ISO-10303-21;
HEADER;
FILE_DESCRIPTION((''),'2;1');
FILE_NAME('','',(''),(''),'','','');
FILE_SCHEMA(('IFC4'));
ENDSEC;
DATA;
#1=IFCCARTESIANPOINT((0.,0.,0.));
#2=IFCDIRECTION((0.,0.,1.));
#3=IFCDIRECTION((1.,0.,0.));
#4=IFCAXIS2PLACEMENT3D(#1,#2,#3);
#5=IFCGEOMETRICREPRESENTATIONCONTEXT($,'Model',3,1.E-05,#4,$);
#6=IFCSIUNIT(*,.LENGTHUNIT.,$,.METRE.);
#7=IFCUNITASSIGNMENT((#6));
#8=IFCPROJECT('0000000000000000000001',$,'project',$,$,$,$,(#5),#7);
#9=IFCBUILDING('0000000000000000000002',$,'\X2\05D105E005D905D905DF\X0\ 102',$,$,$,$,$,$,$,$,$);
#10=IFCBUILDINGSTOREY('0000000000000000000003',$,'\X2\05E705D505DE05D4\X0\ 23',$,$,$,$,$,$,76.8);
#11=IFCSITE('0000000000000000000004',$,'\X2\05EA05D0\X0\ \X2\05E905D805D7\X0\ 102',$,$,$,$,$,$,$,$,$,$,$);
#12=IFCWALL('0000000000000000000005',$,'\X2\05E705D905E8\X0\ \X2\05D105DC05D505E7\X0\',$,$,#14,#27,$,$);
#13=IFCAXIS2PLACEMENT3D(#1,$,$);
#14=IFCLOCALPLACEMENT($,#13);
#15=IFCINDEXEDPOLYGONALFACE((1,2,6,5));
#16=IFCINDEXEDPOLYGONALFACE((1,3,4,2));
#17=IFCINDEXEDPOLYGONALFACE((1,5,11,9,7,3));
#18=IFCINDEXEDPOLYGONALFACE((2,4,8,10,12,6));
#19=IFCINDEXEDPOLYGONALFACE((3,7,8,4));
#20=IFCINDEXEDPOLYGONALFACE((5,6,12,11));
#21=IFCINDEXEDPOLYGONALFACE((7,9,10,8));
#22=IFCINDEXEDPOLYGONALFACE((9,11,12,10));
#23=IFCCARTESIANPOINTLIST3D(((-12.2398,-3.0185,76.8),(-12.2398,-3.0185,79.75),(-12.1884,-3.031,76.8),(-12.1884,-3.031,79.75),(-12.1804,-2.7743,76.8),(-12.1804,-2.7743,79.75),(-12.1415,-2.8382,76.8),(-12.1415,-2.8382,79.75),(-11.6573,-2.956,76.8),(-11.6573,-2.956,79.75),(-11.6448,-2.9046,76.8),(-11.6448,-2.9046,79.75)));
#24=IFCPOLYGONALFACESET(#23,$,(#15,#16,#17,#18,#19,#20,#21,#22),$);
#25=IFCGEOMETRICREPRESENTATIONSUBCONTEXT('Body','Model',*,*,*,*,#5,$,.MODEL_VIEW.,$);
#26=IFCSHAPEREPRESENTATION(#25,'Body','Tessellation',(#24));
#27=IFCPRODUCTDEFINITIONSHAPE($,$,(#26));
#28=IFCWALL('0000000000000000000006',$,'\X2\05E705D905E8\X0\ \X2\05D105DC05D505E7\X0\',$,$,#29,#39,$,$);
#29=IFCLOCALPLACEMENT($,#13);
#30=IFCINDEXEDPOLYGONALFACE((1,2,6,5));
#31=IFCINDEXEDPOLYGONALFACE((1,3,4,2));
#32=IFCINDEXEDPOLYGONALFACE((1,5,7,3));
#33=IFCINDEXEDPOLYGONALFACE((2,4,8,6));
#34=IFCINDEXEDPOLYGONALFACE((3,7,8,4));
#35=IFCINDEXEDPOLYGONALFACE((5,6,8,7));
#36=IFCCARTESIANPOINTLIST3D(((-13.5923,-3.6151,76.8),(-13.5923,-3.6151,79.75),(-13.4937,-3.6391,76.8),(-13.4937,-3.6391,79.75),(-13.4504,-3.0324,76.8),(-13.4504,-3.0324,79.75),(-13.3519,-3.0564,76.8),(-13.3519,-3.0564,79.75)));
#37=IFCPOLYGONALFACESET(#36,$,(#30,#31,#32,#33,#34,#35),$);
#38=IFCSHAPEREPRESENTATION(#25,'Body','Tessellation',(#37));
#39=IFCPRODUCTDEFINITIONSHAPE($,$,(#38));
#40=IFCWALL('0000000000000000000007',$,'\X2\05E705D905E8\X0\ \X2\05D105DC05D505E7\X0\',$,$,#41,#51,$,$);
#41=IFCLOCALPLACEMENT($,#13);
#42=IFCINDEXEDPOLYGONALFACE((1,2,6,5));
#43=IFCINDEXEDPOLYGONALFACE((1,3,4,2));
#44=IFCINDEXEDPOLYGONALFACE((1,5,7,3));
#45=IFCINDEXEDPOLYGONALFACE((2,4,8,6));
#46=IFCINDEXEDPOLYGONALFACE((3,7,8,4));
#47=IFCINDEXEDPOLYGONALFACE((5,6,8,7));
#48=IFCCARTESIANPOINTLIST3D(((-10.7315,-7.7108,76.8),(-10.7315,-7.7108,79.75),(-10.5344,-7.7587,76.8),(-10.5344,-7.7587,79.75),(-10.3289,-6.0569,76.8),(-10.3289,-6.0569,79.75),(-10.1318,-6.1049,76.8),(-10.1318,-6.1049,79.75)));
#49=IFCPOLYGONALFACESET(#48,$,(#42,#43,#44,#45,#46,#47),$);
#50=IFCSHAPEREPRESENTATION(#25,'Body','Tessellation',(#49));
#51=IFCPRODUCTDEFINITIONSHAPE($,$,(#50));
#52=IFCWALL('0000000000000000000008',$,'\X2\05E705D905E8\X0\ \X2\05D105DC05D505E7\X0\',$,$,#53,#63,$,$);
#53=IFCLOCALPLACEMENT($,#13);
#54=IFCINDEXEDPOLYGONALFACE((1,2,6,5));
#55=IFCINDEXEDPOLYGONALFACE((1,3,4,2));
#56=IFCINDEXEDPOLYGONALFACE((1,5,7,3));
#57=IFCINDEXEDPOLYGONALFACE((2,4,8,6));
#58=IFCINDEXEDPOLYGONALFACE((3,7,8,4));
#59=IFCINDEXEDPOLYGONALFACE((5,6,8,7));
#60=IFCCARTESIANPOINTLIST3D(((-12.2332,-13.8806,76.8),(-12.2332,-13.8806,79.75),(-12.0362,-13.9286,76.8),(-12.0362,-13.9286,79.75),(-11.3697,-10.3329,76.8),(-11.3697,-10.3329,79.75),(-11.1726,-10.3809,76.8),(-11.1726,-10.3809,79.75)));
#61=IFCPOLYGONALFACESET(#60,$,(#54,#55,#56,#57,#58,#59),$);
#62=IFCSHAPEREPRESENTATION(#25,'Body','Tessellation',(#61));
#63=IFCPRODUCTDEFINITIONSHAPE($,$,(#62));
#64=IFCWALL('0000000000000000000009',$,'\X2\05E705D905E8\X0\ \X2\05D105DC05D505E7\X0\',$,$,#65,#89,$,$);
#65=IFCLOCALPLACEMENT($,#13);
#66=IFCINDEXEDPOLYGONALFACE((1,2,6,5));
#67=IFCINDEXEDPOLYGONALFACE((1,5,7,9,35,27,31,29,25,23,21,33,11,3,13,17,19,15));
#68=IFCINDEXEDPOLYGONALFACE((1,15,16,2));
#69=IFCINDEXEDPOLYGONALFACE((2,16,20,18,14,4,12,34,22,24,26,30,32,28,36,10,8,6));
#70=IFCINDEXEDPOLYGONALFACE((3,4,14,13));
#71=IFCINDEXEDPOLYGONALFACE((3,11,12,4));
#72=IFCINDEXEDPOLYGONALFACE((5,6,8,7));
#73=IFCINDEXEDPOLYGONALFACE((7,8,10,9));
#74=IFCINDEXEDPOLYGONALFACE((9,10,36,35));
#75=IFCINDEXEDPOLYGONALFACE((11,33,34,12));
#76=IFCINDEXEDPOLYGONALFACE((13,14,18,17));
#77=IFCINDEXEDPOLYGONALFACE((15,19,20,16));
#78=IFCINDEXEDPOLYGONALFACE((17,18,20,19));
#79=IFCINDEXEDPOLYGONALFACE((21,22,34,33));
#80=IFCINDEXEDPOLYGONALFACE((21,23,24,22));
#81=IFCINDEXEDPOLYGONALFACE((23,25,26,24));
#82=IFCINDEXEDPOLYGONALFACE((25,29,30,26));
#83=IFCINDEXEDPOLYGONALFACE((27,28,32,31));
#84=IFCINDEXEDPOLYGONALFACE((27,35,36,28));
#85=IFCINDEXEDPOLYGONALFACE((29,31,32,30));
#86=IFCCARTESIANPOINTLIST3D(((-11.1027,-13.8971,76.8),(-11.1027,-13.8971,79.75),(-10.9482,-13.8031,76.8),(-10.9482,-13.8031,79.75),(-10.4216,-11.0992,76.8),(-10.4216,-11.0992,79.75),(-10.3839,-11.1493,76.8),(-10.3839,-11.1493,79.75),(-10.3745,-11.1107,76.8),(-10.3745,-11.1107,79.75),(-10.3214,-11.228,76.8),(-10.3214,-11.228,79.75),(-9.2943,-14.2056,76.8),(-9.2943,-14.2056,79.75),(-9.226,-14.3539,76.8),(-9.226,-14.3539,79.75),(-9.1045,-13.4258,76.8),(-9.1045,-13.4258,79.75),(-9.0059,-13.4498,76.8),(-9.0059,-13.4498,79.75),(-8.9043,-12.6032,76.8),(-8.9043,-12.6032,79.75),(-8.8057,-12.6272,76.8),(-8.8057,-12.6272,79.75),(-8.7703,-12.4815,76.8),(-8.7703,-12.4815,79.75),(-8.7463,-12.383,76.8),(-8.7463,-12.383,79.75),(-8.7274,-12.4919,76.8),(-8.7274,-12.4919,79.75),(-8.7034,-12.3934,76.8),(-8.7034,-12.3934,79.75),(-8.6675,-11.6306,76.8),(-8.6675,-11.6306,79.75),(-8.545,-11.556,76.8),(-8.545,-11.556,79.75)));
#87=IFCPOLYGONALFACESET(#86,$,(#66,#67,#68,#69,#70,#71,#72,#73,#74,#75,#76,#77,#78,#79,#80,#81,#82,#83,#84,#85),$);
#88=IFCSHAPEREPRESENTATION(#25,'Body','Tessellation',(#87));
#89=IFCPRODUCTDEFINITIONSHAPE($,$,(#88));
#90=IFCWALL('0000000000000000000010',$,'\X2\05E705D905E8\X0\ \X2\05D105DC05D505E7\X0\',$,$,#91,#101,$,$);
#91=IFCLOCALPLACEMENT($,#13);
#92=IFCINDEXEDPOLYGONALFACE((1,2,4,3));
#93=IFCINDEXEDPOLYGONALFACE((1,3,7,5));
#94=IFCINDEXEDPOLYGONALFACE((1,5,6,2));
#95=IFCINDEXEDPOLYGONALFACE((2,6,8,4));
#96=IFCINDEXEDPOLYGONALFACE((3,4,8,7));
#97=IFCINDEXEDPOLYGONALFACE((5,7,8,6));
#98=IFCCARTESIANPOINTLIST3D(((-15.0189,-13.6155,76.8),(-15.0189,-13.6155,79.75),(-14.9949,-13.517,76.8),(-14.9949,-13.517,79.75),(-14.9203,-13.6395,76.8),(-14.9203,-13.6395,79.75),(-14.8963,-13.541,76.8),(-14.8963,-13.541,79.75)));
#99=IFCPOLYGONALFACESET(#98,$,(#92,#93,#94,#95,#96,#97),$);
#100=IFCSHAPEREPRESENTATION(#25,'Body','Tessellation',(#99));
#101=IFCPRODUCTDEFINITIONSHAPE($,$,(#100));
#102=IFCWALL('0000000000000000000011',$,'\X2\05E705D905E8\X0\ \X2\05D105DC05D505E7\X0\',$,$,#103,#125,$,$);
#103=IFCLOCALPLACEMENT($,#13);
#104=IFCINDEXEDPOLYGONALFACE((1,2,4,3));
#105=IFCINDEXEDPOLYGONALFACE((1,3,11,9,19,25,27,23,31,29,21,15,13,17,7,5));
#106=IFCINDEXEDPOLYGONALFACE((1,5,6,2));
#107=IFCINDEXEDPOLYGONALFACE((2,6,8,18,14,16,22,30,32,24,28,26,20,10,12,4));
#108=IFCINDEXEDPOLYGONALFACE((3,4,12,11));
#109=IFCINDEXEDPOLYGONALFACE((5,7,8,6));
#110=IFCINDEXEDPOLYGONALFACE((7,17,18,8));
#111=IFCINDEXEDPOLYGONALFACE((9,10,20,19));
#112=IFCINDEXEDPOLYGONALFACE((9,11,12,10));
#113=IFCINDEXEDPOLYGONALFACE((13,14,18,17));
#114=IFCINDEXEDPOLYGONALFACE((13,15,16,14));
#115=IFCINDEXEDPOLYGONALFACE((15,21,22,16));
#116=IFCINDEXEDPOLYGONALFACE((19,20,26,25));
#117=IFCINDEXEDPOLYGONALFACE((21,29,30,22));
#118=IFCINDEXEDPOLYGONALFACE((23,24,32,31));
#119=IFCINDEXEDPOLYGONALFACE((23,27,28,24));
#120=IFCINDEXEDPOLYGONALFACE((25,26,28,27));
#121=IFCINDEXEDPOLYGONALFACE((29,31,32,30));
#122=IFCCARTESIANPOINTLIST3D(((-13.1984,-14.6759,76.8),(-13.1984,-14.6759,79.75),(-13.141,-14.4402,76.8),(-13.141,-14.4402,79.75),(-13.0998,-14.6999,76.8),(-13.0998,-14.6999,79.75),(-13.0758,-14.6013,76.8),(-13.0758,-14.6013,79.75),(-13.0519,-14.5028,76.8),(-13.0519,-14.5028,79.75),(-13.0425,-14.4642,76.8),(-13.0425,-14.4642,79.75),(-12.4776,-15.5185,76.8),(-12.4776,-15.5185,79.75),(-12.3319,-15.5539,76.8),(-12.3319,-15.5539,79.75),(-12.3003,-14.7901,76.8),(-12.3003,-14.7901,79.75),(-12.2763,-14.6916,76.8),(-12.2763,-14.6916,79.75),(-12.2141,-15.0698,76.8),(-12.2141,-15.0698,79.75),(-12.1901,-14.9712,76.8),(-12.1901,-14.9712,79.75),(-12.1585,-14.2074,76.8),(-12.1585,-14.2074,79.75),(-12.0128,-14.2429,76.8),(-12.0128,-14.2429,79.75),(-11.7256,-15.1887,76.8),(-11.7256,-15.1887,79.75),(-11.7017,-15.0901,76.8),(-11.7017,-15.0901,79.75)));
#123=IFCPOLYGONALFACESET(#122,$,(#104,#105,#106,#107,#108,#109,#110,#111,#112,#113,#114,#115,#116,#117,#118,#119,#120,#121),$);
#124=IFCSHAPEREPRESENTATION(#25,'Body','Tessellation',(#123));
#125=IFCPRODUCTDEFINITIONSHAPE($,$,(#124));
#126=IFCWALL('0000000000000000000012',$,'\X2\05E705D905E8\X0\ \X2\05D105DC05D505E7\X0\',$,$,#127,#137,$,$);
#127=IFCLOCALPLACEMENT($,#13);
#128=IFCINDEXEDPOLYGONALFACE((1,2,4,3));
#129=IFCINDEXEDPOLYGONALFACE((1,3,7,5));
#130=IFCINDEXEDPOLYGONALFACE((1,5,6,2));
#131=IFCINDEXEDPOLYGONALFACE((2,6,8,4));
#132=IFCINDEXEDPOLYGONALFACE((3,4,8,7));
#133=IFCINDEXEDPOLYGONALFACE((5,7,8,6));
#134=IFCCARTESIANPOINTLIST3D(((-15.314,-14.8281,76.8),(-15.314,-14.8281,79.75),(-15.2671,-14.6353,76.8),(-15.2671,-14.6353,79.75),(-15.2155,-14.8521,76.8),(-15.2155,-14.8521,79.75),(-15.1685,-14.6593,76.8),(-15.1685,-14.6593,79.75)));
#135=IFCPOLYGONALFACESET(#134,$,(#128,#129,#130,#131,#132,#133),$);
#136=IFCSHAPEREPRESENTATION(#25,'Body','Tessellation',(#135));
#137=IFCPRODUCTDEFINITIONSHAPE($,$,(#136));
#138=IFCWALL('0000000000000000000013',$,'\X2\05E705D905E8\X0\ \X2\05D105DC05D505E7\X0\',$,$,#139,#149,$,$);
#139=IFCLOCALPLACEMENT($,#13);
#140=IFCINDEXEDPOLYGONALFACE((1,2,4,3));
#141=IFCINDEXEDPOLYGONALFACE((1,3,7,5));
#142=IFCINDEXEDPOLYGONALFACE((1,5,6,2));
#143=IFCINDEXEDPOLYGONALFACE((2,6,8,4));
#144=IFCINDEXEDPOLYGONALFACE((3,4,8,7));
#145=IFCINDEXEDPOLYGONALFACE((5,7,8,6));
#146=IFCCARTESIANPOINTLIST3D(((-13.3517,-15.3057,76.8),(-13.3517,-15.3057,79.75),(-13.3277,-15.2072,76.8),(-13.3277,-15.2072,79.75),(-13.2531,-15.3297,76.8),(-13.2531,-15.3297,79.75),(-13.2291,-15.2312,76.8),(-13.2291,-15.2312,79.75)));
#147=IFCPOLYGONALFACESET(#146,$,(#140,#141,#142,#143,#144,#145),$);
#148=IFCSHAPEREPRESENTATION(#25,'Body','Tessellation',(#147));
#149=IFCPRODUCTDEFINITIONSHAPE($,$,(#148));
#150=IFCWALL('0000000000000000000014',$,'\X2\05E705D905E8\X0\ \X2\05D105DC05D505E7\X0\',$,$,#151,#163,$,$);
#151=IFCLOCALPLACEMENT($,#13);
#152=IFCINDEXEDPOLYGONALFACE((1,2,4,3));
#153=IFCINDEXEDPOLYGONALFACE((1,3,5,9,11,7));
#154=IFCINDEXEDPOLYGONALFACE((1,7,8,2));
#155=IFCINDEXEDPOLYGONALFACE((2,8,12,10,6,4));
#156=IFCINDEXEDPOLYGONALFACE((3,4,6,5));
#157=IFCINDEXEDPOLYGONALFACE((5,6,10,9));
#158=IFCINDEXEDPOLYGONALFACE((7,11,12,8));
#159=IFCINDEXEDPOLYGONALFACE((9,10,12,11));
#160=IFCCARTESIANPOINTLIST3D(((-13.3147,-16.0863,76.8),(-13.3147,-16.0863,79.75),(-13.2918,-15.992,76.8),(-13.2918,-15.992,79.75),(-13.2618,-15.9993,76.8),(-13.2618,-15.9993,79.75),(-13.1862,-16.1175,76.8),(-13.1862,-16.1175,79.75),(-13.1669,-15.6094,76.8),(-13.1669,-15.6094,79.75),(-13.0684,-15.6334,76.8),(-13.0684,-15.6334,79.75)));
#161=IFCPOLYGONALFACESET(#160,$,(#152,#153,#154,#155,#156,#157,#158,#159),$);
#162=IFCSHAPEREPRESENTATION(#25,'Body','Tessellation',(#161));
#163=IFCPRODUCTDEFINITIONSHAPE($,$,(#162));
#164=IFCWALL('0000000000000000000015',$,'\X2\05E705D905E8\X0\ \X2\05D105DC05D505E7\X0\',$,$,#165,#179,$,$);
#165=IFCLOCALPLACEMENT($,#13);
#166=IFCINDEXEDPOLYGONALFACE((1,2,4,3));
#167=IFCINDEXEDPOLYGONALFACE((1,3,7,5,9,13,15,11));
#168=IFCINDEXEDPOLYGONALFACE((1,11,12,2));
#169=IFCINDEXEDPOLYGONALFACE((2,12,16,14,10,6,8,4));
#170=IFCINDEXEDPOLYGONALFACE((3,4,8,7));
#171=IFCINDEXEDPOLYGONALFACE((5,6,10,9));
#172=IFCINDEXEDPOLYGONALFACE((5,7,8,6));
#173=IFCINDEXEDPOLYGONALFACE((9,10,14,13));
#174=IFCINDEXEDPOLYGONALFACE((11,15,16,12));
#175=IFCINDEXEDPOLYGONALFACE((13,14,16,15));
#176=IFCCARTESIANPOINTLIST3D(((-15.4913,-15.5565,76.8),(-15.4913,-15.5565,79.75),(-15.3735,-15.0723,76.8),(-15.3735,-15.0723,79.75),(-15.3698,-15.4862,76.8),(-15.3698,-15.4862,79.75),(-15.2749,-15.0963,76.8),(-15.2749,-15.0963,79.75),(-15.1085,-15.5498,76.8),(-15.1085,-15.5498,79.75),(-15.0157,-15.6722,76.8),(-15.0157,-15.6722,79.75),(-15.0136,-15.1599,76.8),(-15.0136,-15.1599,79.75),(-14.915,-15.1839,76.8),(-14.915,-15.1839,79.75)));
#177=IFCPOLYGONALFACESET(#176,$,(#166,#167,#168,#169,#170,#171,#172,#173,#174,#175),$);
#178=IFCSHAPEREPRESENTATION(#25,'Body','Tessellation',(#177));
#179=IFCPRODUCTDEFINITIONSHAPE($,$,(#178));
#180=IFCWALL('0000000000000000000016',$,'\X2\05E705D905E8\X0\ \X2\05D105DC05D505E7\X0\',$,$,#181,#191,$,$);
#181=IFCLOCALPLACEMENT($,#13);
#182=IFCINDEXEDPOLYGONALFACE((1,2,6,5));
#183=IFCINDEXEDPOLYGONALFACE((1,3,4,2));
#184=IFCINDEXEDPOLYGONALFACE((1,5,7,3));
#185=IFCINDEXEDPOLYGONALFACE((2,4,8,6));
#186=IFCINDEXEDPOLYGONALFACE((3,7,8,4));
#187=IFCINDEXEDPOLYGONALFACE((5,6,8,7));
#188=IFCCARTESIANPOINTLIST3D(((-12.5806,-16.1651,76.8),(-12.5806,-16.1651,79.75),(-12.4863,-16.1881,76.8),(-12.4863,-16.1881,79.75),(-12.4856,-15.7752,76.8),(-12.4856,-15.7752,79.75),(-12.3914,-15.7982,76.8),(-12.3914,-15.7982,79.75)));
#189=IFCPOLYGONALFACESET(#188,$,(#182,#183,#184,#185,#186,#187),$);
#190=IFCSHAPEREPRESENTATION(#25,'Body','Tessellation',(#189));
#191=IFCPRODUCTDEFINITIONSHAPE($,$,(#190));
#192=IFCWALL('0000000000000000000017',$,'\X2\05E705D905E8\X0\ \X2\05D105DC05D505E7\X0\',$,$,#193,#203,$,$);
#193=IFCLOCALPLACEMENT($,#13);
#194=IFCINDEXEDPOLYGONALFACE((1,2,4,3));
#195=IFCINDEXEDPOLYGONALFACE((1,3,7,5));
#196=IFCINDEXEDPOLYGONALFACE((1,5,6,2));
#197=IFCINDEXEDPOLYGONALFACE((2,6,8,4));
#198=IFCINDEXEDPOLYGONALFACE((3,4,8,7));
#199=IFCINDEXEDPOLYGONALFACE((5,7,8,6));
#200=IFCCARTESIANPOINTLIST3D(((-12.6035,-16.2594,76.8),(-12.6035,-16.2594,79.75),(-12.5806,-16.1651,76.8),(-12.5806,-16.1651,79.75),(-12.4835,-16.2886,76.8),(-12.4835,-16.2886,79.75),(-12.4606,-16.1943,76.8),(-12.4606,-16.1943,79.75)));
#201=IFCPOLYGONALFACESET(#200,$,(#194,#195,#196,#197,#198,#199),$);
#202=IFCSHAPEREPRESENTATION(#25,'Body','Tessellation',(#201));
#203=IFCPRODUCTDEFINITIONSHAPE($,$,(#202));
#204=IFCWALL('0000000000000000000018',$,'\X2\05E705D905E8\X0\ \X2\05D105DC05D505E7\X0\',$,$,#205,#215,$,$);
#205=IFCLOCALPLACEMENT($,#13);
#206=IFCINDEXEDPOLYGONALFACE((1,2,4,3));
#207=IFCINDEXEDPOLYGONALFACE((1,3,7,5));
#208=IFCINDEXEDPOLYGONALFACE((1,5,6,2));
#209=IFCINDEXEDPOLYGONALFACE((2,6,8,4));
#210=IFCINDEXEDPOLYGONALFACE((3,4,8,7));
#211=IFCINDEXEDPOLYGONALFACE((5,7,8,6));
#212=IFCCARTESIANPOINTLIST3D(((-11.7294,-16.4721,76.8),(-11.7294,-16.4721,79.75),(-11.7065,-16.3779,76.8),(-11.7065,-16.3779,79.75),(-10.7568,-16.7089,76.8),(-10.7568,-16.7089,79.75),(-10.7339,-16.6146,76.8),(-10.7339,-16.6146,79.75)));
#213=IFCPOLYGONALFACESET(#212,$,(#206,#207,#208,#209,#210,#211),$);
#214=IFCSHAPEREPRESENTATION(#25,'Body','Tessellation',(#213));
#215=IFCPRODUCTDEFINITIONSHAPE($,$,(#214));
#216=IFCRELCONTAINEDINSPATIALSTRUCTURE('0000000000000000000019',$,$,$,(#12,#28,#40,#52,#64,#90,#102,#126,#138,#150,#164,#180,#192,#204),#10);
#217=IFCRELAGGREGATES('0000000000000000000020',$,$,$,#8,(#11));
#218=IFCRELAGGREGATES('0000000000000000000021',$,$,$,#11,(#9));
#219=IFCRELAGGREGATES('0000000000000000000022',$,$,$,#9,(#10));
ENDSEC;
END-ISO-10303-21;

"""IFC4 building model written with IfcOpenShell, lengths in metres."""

from ifc_helpers import new_model, si_unit, frame, origin_with_axes, context, subcontext, project, spatial, polyline, outline, extrude, element, save


model = new_model("IFC4")

# Units and contexts
model_context = context("Model", 3, precision=1e-05, world=origin_with_axes())
body_context = subcontext(model_context, "Body", "Model", "MODEL_VIEW")
ifc_project = project(units=[si_unit("LENGTHUNIT", "METRE")], contexts=[model_context])

# Site, building, storey
site = spatial("IfcSite", under=ifc_project, Name="תא שטח 102")
building = spatial("IfcBuilding", under=site, Name="בניין 102")
storey = spatial("IfcBuildingStorey", under=building, Name="קומה 23", Elevation=76.8)

# Walls
element("IfcWall", 1, inside=storey, Name="קיר בלוק", context=body_context, shape_type="SweptSolid", body=[
    extrude(outline(polyline([(-12.1415, -2.8382), (-11.6573, -2.956), (-11.6448, -2.9046), (-12.1804, -2.7743), (-12.2398, -3.0185), (-12.1884, -3.031), (-12.1415, -2.8382)])), frame((0.0, 0.0, 76.8)), (0.0, 0.0, 1.0), 2.95),
])
element("IfcWall", 2, inside=storey, Name="קיר בלוק", context=body_context, shape_type="SweptSolid", body=[
    extrude(outline(polyline([(-13.4504, -3.0324), (-13.5923, -3.6151), (-13.4937, -3.6391), (-13.3519, -3.0564), (-13.4504, -3.0324)])), frame((0.0, 0.0, 76.8)), (0.0, 0.0, 1.0), 2.95),
])
element("IfcWall", 3, inside=storey, Name="קיר בלוק", context=body_context, shape_type="SweptSolid", body=[
    extrude(outline(polyline([(-10.7315, -7.7108), (-10.5344, -7.7587), (-10.1318, -6.1049), (-10.3289, -6.0569), (-10.7315, -7.7108)])), frame((0.0, 0.0, 76.8)), (0.0, 0.0, 1.0), 2.95),
])
element("IfcWall", 4, inside=storey, Name="קיר בלוק", context=body_context, shape_type="SweptSolid", body=[
    extrude(outline(polyline([(-12.2332, -13.8806), (-12.0362, -13.9286), (-11.1726, -10.3809), (-11.3697, -10.3329), (-12.2332, -13.8806)])), frame((0.0, 0.0, 76.8)), (0.0, 0.0, 1.0), 2.95),
])
element("IfcWall", 5, inside=storey, Name="קיר בלוק", context=body_context, shape_type="SweptSolid", body=[
    extrude(outline(polyline([(-11.1027, -13.8971), (-9.226, -14.3539), (-9.0059, -13.4498), (-9.1045, -13.4258), (-9.2943, -14.2056), (-10.9482, -13.8031), (-10.3214, -11.228), (-8.6675, -11.6306), (-8.9043, -12.6032), (-8.8057, -12.6272), (-8.7703, -12.4815), (-8.7274, -12.4919), (-8.7034, -12.3934), (-8.7463, -12.383), (-8.545, -11.556), (-10.3745, -11.1107), (-10.3839, -11.1493), (-10.4216, -11.0992), (-11.1027, -13.8971)])), frame((0.0, 0.0, 76.8)), (0.0, 0.0, 1.0), 2.95),
])
element("IfcWall", 6, inside=storey, Name="קיר בלוק", context=body_context, shape_type="SweptSolid", body=[
    extrude(outline(polyline([(-14.9949, -13.517), (-15.0189, -13.6155), (-14.9203, -13.6395), (-14.8963, -13.541), (-14.9949, -13.517)])), frame((0.0, 0.0, 76.8)), (0.0, 0.0, 1.0), 2.95),
])
element("IfcWall", 7, inside=storey, Name="קיר בלוק", context=body_context, shape_type="SweptSolid", body=[
    extrude(outline(polyline([(-13.0998, -14.6999), (-13.0758, -14.6013), (-12.3003, -14.7901), (-12.4776, -15.5185), (-12.3319, -15.5539), (-12.2141, -15.0698), (-11.7256, -15.1887), (-11.7017, -15.0901), (-12.1901, -14.9712), (-12.0128, -14.2429), (-12.1585, -14.2074), (-12.2763, -14.6916), (-13.0519, -14.5028), (-13.0425, -14.4642), (-13.141, -14.4402), (-13.1984, -14.6759), (-13.0998, -14.6999)])), frame((0.0, 0.0, 76.8)), (0.0, 0.0, 1.0), 2.95),
])
element("IfcWall", 8, inside=storey, Name="קיר בלוק", context=body_context, shape_type="SweptSolid", body=[
    extrude(outline(polyline([(-15.1685, -14.6593), (-15.2671, -14.6353), (-15.314, -14.8281), (-15.2155, -14.8521), (-15.1685, -14.6593)])), frame((0.0, 0.0, 76.8)), (0.0, 0.0, 1.0), 2.95),
])
element("IfcWall", 9, inside=storey, Name="קיר בלוק", context=body_context, shape_type="SweptSolid", body=[
    extrude(outline(polyline([(-13.3277, -15.2072), (-13.3517, -15.3057), (-13.2531, -15.3297), (-13.2291, -15.2312), (-13.3277, -15.2072)])), frame((0.0, 0.0, 76.8)), (0.0, 0.0, 1.0), 2.95),
])
element("IfcWall", 10, inside=storey, Name="קיר בלוק", context=body_context, shape_type="SweptSolid", body=[
    extrude(outline(polyline([(-13.3147, -16.0863), (-13.1862, -16.1175), (-13.0684, -15.6334), (-13.1669, -15.6094), (-13.2618, -15.9993), (-13.2918, -15.992), (-13.3147, -16.0863)])), frame((0.0, 0.0, 76.8)), (0.0, 0.0, 1.0), 2.95),
])
element("IfcWall", 11, inside=storey, Name="קיר בלוק", context=body_context, shape_type="SweptSolid", body=[
    extrude(outline(polyline([(-15.3735, -15.0723), (-15.4913, -15.5565), (-15.0157, -15.6722), (-14.915, -15.1839), (-15.0136, -15.1599), (-15.1085, -15.5498), (-15.3698, -15.4862), (-15.2749, -15.0963), (-15.3735, -15.0723)])), frame((0.0, 0.0, 76.8)), (0.0, 0.0, 1.0), 2.95),
])
element("IfcWall", 12, inside=storey, Name="קיר בלוק", context=body_context, shape_type="SweptSolid", body=[
    extrude(outline(polyline([(-12.4856, -15.7752), (-12.5806, -16.1651), (-12.4863, -16.1881), (-12.3914, -15.7982), (-12.4856, -15.7752)])), frame((0.0, 0.0, 76.8)), (0.0, 0.0, 1.0), 2.95),
])
element("IfcWall", 13, inside=storey, Name="קיר בלוק", context=body_context, shape_type="SweptSolid", body=[
    extrude(outline(polyline([(-12.4835, -16.2886), (-12.4606, -16.1943), (-12.5806, -16.1651), (-12.6035, -16.2594), (-12.4835, -16.2886)])), frame((0.0, 0.0, 76.8)), (0.0, 0.0, 1.0), 2.95),
])
element("IfcWall", 14, inside=storey, Name="קיר בלוק", context=body_context, shape_type="SweptSolid", body=[
    extrude(outline(polyline([(-11.7294, -16.4721), (-10.7568, -16.7089), (-10.7339, -16.6146), (-11.7065, -16.3779), (-11.7294, -16.4721)])), frame((0.0, 0.0, 76.8)), (0.0, 0.0, 1.0), 2.95),
])

save(model, "model.ifc")
